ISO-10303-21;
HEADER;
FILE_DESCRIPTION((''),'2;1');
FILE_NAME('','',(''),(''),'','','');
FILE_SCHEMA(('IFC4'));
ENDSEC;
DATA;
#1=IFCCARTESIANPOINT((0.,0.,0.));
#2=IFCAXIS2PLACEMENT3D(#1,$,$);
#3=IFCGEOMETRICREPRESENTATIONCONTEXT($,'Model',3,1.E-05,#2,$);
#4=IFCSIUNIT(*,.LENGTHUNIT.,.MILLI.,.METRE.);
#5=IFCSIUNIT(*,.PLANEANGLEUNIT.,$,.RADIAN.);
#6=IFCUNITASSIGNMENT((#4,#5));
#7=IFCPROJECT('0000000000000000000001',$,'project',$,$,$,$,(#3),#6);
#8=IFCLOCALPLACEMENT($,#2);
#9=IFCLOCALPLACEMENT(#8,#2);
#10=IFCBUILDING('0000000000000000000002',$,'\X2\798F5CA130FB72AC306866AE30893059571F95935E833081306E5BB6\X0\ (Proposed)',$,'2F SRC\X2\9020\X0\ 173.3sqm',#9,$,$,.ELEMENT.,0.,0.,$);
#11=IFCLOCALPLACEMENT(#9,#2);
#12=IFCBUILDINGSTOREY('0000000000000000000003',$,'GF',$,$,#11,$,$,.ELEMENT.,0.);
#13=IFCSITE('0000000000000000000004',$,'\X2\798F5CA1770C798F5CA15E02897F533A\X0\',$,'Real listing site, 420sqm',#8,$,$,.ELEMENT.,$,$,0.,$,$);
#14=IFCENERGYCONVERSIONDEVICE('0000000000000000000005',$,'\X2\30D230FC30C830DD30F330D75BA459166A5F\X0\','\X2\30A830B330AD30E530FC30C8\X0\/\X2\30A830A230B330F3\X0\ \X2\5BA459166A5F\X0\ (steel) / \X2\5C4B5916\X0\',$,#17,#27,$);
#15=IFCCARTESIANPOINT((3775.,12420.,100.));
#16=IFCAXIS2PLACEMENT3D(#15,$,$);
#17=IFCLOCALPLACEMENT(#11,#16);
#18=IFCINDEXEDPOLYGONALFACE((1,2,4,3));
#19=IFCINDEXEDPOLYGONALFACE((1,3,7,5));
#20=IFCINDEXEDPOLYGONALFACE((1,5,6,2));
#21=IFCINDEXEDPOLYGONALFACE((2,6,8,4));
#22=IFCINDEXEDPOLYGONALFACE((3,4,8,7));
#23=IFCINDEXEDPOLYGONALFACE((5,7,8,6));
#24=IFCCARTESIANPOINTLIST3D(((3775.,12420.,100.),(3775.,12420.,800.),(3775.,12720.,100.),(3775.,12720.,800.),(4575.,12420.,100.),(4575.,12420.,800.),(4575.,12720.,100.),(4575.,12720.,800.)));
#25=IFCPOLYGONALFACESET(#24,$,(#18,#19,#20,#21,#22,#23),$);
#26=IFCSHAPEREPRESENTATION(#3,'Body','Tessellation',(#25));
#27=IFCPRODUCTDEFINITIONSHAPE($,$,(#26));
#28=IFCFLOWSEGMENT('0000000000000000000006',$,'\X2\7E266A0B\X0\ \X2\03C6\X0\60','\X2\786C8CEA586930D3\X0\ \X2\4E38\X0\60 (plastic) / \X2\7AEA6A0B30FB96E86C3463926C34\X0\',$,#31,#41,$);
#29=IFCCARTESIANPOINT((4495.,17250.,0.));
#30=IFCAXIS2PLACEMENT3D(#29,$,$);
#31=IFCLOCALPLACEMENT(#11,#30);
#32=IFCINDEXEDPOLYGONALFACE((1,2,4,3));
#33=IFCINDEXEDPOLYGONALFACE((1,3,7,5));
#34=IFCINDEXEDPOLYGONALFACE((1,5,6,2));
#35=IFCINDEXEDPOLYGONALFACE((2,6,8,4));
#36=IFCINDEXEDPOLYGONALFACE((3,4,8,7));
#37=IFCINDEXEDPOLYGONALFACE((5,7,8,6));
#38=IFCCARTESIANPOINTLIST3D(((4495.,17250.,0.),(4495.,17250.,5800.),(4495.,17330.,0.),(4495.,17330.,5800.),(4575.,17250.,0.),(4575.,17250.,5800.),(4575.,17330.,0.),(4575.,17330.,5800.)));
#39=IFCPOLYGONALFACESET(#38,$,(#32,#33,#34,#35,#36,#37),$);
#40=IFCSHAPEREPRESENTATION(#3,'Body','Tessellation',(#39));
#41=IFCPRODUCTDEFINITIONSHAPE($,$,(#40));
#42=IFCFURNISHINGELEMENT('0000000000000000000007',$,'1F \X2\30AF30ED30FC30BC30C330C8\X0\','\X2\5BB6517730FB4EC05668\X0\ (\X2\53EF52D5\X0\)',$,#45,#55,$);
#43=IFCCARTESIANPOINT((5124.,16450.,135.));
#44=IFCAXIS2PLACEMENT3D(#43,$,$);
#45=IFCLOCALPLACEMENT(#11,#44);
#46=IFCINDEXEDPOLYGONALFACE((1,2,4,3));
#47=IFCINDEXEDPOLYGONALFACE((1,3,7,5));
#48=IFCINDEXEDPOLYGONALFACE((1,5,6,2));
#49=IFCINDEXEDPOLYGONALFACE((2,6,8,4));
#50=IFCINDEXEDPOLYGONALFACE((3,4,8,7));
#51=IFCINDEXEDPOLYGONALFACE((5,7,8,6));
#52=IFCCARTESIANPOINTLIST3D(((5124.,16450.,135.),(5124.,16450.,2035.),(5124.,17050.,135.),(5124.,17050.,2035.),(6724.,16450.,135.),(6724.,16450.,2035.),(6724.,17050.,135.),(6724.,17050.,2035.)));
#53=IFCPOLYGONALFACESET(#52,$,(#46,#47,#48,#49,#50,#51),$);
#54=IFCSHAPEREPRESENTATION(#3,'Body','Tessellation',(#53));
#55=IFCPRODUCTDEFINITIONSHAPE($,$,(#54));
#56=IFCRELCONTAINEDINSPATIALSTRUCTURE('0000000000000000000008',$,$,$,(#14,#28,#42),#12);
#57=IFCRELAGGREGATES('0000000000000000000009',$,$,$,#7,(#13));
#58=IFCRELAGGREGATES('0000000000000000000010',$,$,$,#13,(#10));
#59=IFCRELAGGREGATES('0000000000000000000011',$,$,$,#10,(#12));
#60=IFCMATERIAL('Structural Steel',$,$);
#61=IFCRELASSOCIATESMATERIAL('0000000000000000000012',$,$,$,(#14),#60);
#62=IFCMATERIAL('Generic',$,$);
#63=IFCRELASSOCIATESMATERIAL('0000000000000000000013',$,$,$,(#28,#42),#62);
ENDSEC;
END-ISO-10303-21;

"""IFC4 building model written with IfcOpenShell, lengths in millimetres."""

from ifc_helpers import new_model, si_unit, frame, frame_2d, origin, place, context, project, spatial, rectangle, extrude, material, element, save


model = new_model("IFC4")

# Units and contexts
model_context = context("Model", 3, precision=1e-05, world=origin())
ifc_project = project(units=[si_unit("LENGTHUNIT", "METRE", prefix="MILLI"), si_unit("PLANEANGLEUNIT", "RADIAN")], contexts=[model_context])

# Site, building, storey
site_placement = place(None, origin())
site = spatial("IfcSite", under=ifc_project, at=site_placement, Name="福岡県福岡市西区", ObjectType="Real listing site, 420sqm", CompositionType="ELEMENT", RefElevation=0.0)
building_placement = place(site_placement, origin())
building = spatial("IfcBuilding", under=site, at=building_placement, Name="福岡・犬と暮らす土間広めの家 (Proposed)", ObjectType="2F SRC造 173.3sqm", CompositionType="ELEMENT", ElevationOfRefHeight=0.0, ElevationOfTerrain=0.0)
storey_placement = place(building_placement, origin())
storey = spatial("IfcBuildingStorey", under=building, at=storey_placement, Name="GF", CompositionType="ELEMENT", Elevation=0.0)

# Shared definitions
ifc_material_1 = material(Name="Generic")

# Energy conversion device
ifc_material_2 = material(Name="Structural Steel")
energy_conversion_device_placement = place(storey_placement, frame((3775.0, 12420.0, 100.0)))
element("IfcEnergyConversionDevice", 1, at=energy_conversion_device_placement, inside=storey, material=ifc_material_2, Name="ヒートポンプ室外機", Description="エコキュート/エアコン 室外機 (steel) / 屋外", context=model_context, shape_type="SweptSolid", body=[
    extrude(rectangle(XDim=800.0, YDim=300.0, at=frame_2d((400.0, 150.0))), frame((3775.0, 12420.0, 100.0)), (0.0, 0.0, 1.0), 700.0),
])

# Flow segment
flow_segment_placement = place(storey_placement, frame((4495.0, 17250.0, 0.0)))
element("IfcFlowSegment", 2, at=flow_segment_placement, inside=storey, material=ifc_material_1, Name="縦樋 φ60", Description="硬質塩ビ 丸60 (plastic) / 竪樋・雨水排水", context=model_context, shape_type="SweptSolid", body=[
    extrude(rectangle(XDim=80.0, YDim=80.0, at=frame_2d((40.0, 40.0))), frame((4495.0, 17250.0, 0.0)), (0.0, 0.0, 1.0), 5800.0),
])

# Furnishing element
furnishing_placement = place(storey_placement, frame((5124.0, 16450.0, 135.0)))
element("IfcFurnishingElement", 3, at=furnishing_placement, inside=storey, material=ifc_material_1, Name="1F クローゼット", Description="家具・什器 (可動)", context=model_context, shape_type="SweptSolid", body=[
    extrude(rectangle(XDim=1600.0, YDim=600.0, at=frame_2d((800.0, 300.0))), frame((5124.0, 16450.0, 135.0)), (0.0, 0.0, 1.0), 1900.0),
])

save(model, "model.ifc")
